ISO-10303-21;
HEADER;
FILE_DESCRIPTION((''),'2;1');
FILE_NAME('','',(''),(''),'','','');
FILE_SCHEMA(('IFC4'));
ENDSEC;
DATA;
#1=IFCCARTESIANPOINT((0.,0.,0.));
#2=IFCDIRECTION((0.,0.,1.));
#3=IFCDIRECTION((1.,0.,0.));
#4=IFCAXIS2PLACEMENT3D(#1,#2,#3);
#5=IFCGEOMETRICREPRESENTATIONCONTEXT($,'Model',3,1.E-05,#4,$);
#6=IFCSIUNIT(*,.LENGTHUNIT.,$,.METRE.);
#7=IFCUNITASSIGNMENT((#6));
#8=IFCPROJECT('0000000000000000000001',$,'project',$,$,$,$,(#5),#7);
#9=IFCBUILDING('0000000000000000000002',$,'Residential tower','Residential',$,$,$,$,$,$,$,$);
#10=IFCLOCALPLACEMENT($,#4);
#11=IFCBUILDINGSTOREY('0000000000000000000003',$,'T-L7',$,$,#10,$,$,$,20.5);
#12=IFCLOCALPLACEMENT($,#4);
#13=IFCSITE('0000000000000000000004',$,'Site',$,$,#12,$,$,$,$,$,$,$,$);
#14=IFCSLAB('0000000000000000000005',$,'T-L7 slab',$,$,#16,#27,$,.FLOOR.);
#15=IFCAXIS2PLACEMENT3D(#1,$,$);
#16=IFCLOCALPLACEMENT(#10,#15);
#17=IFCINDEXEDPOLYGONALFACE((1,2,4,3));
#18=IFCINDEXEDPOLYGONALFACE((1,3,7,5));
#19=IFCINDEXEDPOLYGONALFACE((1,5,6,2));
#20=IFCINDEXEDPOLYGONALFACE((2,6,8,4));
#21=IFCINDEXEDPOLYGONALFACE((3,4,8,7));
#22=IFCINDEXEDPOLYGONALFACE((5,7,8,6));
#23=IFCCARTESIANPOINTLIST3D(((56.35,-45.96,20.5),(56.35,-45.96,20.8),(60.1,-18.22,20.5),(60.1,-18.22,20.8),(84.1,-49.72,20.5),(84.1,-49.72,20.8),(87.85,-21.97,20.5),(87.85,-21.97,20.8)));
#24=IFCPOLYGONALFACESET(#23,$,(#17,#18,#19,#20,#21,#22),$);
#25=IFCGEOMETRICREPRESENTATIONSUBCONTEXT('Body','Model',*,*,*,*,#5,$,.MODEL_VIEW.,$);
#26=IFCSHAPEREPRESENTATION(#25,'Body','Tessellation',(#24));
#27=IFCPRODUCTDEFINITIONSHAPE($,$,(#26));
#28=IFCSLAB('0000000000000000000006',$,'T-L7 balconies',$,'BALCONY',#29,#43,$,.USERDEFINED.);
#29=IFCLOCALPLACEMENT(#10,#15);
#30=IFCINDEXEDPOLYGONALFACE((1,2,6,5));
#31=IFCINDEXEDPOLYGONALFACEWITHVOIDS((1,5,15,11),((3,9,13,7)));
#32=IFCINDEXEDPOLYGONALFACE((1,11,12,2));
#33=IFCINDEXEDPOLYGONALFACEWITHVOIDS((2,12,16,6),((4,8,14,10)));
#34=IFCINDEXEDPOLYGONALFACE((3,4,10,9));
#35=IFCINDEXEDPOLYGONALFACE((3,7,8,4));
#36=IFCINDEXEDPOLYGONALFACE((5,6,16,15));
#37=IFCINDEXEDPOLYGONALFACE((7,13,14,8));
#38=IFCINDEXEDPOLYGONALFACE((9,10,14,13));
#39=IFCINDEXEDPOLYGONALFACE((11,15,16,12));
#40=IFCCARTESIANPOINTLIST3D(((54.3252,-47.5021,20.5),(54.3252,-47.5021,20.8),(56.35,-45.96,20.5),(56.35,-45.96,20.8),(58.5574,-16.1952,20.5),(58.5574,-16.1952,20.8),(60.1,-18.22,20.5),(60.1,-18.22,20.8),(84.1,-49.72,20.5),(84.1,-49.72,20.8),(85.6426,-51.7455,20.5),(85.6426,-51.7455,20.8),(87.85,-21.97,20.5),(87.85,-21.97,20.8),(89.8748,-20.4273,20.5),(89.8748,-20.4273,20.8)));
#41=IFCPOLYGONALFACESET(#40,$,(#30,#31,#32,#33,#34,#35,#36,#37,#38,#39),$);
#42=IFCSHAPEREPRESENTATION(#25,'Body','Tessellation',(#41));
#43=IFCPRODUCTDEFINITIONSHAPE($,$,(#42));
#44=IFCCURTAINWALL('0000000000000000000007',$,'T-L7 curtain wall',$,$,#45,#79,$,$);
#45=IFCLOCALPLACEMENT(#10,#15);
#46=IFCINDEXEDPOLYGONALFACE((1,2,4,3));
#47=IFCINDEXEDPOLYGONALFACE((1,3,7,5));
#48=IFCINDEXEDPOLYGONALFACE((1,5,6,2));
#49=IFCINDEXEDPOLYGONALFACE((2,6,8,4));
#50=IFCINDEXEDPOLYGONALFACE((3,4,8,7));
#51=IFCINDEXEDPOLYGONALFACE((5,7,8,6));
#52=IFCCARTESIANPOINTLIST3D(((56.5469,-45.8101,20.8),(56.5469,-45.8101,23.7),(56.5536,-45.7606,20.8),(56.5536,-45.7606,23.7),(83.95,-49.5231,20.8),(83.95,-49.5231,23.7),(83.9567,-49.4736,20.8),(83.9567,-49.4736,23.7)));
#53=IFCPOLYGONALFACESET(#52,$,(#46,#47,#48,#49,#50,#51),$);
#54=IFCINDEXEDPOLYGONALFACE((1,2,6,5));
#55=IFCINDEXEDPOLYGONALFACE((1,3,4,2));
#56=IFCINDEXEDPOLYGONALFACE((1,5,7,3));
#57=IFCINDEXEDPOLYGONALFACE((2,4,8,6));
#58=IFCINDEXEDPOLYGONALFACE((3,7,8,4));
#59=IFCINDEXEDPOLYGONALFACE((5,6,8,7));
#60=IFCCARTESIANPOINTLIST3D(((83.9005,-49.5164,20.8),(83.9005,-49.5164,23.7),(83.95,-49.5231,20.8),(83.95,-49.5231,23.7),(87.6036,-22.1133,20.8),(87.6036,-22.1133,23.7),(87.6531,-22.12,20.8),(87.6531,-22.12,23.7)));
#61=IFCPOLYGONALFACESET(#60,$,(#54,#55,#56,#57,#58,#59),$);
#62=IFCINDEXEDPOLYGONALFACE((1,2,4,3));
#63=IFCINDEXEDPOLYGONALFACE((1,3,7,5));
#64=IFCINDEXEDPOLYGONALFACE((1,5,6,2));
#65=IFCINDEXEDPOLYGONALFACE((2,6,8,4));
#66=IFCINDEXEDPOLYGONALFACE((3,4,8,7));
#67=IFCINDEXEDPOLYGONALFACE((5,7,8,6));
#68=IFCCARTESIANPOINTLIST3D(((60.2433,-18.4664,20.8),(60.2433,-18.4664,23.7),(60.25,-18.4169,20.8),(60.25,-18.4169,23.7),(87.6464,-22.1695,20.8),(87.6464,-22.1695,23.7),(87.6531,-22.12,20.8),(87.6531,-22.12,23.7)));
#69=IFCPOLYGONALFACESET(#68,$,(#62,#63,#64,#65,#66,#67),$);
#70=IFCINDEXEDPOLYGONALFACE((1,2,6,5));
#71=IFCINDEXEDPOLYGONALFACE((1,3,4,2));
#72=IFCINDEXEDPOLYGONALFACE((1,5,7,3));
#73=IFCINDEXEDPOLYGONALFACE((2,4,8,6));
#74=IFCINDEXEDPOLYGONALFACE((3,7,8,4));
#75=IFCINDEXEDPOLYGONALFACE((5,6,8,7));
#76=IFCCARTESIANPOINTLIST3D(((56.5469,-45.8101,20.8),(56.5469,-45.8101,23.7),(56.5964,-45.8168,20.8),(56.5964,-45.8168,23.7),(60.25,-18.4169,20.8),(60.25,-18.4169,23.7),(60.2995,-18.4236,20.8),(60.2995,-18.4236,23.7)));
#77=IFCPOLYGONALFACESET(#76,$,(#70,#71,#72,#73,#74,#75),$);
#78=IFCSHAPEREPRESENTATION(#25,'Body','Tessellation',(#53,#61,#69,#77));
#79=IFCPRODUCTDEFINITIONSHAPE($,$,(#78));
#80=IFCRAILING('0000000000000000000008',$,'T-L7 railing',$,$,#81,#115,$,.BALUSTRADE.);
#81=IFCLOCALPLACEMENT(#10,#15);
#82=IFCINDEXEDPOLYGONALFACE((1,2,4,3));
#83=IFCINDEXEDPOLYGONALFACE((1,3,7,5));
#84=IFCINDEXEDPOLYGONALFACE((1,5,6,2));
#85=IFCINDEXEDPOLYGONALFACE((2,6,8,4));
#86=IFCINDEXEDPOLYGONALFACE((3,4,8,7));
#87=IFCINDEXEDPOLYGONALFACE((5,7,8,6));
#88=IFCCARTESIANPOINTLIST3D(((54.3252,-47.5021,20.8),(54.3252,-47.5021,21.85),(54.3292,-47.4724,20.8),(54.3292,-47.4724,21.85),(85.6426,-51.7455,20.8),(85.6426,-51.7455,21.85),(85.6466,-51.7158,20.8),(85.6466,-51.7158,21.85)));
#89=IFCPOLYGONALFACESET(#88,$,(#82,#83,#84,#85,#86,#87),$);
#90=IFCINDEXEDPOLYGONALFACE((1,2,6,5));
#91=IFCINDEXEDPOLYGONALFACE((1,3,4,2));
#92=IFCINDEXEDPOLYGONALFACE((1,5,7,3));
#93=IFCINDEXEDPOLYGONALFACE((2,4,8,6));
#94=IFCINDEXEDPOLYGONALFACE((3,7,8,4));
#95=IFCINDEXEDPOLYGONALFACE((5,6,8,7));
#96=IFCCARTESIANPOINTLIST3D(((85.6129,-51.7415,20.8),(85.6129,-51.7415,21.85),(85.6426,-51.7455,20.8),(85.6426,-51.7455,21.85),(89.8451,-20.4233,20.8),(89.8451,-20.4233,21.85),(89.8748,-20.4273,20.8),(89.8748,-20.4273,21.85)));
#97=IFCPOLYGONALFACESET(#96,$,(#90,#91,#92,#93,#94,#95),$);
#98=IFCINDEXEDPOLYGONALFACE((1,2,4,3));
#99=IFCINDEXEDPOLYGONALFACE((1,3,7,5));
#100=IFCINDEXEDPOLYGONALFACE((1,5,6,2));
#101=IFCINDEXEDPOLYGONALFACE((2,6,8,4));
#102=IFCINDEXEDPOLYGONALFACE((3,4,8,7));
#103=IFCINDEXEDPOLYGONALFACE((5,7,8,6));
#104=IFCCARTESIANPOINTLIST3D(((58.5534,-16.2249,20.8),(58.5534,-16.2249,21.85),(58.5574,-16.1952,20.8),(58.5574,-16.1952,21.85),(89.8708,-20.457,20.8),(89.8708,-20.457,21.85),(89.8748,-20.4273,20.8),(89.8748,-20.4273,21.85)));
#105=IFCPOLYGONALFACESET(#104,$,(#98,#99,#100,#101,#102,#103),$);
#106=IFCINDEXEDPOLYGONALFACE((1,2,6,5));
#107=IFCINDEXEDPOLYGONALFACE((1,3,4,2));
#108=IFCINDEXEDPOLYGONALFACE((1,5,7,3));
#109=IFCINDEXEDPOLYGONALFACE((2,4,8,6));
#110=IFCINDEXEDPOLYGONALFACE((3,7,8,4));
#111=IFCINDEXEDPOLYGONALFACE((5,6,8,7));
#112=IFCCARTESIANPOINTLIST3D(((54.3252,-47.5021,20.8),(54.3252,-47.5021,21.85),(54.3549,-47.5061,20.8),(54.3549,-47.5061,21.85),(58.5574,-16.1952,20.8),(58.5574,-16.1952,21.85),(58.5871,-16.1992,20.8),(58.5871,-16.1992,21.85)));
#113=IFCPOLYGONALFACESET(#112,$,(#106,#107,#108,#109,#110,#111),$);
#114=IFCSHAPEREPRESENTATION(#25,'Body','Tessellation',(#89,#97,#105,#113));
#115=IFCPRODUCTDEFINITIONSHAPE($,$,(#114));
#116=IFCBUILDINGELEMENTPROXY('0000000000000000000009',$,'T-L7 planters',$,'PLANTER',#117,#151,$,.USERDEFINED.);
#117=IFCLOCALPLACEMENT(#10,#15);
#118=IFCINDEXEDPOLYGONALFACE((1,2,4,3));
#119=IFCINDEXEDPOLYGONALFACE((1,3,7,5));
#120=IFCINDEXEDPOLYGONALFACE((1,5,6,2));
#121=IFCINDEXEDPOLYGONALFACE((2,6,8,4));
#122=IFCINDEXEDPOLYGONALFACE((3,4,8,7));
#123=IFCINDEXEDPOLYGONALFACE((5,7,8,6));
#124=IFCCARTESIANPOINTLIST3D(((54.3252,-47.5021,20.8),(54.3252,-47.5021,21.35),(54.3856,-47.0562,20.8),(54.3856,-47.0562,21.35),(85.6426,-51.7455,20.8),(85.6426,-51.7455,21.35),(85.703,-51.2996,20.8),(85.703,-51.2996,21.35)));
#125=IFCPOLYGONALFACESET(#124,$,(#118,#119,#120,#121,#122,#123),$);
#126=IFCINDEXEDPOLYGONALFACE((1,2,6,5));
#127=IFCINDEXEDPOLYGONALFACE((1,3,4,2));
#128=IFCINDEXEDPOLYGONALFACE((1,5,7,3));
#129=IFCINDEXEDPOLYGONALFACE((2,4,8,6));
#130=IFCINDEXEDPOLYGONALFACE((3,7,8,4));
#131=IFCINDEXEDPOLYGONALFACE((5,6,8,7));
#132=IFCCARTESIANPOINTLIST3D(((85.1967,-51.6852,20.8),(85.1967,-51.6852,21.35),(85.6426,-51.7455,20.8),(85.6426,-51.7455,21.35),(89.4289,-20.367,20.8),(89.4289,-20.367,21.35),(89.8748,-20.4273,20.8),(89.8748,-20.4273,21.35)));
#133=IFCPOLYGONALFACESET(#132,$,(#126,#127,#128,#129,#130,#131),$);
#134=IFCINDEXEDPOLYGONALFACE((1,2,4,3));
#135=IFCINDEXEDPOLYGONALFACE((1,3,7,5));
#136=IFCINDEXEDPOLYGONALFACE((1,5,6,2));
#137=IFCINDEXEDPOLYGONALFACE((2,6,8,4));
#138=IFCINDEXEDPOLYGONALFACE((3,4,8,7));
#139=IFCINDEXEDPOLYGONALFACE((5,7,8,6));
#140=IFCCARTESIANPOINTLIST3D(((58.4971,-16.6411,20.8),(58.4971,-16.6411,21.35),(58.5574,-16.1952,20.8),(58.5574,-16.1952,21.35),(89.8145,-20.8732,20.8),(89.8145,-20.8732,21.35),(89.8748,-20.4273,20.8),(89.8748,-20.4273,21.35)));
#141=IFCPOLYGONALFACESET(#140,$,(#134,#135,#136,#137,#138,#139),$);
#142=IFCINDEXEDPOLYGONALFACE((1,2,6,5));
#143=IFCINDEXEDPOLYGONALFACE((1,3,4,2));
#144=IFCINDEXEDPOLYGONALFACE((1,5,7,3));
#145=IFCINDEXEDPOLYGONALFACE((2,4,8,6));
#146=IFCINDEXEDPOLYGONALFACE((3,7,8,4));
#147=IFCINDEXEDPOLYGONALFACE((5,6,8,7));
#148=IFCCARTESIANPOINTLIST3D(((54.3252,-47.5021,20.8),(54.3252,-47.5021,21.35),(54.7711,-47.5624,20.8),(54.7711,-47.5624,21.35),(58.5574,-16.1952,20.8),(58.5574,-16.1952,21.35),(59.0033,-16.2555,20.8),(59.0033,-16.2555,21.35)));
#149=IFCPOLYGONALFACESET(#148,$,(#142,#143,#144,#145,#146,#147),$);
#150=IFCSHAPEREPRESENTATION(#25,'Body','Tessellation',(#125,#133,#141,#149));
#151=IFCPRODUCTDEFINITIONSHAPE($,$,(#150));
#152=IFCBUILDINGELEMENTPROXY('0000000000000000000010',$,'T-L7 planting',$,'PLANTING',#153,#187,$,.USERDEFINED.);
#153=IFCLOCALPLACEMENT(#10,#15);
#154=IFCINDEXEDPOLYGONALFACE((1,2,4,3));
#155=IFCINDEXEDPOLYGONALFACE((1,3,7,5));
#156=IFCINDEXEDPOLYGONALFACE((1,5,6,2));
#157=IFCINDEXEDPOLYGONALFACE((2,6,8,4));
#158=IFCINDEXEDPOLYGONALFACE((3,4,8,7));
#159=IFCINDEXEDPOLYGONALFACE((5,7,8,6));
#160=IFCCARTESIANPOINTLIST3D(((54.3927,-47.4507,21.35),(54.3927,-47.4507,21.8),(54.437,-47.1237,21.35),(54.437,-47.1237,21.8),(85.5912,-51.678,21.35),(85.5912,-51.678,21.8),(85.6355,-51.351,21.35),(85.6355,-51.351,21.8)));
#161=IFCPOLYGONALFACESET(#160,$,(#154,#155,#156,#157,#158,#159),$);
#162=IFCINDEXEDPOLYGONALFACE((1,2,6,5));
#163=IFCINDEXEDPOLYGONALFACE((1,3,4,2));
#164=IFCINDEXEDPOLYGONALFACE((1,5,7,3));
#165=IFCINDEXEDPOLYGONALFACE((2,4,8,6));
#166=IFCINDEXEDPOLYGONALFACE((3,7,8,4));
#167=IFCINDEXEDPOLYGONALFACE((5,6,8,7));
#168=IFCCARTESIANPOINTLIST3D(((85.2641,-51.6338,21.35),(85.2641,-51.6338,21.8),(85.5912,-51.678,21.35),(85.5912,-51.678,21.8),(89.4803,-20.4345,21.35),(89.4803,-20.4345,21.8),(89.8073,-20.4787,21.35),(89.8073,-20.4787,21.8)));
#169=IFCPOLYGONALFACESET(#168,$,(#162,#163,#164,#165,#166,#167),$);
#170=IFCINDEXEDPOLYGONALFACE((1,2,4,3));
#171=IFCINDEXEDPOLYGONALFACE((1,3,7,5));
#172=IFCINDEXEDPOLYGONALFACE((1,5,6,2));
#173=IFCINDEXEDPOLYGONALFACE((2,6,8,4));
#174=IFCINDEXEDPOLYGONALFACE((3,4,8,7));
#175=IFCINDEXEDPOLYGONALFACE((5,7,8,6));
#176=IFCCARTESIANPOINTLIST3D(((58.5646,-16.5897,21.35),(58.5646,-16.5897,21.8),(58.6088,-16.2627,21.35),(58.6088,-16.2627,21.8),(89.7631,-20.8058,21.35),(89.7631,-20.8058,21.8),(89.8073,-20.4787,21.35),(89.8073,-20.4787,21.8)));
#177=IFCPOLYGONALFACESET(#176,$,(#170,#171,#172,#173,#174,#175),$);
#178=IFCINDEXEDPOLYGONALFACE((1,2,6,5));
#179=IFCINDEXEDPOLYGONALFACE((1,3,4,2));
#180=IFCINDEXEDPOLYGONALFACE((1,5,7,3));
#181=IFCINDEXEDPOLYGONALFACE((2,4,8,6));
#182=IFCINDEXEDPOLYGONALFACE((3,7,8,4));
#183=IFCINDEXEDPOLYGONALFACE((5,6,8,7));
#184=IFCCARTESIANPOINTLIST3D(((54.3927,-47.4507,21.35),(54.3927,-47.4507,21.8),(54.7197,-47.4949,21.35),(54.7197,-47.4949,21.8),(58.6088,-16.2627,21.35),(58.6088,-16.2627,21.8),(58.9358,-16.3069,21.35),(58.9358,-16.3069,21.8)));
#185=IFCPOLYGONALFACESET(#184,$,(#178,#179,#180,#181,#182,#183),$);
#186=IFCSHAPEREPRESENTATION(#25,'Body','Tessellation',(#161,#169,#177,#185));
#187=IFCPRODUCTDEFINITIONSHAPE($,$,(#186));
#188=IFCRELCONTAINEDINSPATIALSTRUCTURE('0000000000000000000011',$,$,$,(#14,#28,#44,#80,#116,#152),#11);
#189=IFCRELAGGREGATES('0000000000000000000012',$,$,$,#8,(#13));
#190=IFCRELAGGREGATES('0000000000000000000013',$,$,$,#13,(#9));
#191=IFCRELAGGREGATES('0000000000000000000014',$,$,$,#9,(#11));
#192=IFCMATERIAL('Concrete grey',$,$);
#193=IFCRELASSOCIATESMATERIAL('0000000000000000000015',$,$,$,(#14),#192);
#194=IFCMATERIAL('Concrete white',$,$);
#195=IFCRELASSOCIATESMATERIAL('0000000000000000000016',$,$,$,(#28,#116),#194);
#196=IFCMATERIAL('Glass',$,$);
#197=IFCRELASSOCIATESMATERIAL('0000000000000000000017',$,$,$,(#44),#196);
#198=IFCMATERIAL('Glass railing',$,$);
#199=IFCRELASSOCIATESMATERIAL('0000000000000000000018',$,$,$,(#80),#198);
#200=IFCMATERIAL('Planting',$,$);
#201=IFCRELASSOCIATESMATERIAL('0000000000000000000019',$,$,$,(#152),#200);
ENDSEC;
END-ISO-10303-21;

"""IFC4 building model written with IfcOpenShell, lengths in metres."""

from ifc_helpers import new_model, si_unit, frame, origin_with_axes, place, context, subcontext, project, spatial, polyline, outline, extrude, material, element, save


model = new_model("IFC4")

# Units and contexts
model_context = context("Model", 3, precision=1e-05, world=origin_with_axes())
body_context = subcontext(model_context, "Body", "Model", "MODEL_VIEW")
ifc_project = project(units=[si_unit("LENGTHUNIT", "METRE")], contexts=[model_context])

# Site, building, storey
site_placement = place(None, origin_with_axes())
site = spatial("IfcSite", under=ifc_project, at=site_placement, Name="Site")
building = spatial("IfcBuilding", under=site, Name="Residential tower", Description="Residential")
storey_placement = place(None, origin_with_axes())
storey = spatial("IfcBuildingStorey", under=building, at=storey_placement, Name="T-L7", Elevation=20.5)

# Slabs
ifc_material_1 = material(Name="Concrete grey")
slab_1_placement = place(storey_placement, origin_with_axes())
element("IfcSlab", 1, at=slab_1_placement, inside=storey, material=ifc_material_1, Name="T-L7 slab", PredefinedType="FLOOR", context=body_context, shape_type="SweptSolid", body=[
    extrude(outline(polyline([(56.35, -45.96), (84.1, -49.72), (87.85, -21.97), (60.1, -18.22), (56.35, -45.96)])), frame((0.0, 0.0, 20.5), z_axis=(0.0, 0.0, 1.0), x_axis=(1.0, 0.0, 0.0)), (0.0, 0.0, 1.0), 0.3),
])
ifc_material_2 = material(Name="Concrete white")
slab_2_placement = place(storey_placement, origin_with_axes())
element("IfcSlab", 2, at=slab_2_placement, inside=storey, material=ifc_material_2, Name="T-L7 balconies", ObjectType="BALCONY", PredefinedType="USERDEFINED", context=body_context, shape_type="SweptSolid", body=[
    extrude(outline(polyline([(54.3252, -47.5021), (85.6426, -51.7455), (89.8748, -20.4273), (58.5574, -16.1952), (54.3252, -47.5021)]), holes=[polyline([(56.35, -45.96), (84.1, -49.72), (87.85, -21.97), (60.1, -18.22), (56.35, -45.96)])]), frame((0.0, 0.0, 20.5), z_axis=(0.0, 0.0, 1.0), x_axis=(1.0, 0.0, 0.0)), (0.0, 0.0, 1.0), 0.3),
])

# Curtain wall
ifc_material_3 = material(Name="Glass")
curtain_wall_placement = place(storey_placement, origin_with_axes())
element("IfcCurtainWall", 3, at=curtain_wall_placement, inside=storey, material=ifc_material_3, Name="T-L7 curtain wall", context=body_context, shape_type="SweptSolid", body=[
    extrude(outline(polyline([(56.5469, -45.8101), (83.95, -49.5231), (83.9567, -49.4736), (56.5536, -45.7606), (56.5469, -45.8101)])), frame((0.0, 0.0, 20.8), z_axis=(0.0, 0.0, 1.0), x_axis=(1.0, 0.0, 0.0)), (0.0, 0.0, 1.0), 2.9),
    extrude(outline(polyline([(83.95, -49.5231), (87.6531, -22.12), (87.6036, -22.1133), (83.9005, -49.5164), (83.95, -49.5231)])), frame((0.0, 0.0, 20.8), z_axis=(0.0, 0.0, 1.0), x_axis=(1.0, 0.0, 0.0)), (0.0, 0.0, 1.0), 2.9),
    extrude(outline(polyline([(87.6531, -22.12), (60.25, -18.4169), (60.2433, -18.4664), (87.6464, -22.1695), (87.6531, -22.12)])), frame((0.0, 0.0, 20.8), z_axis=(0.0, 0.0, 1.0), x_axis=(1.0, 0.0, 0.0)), (0.0, 0.0, 1.0), 2.9),
    extrude(outline(polyline([(60.25, -18.4169), (56.5469, -45.8101), (56.5964, -45.8168), (60.2995, -18.4236), (60.25, -18.4169)])), frame((0.0, 0.0, 20.8), z_axis=(0.0, 0.0, 1.0), x_axis=(1.0, 0.0, 0.0)), (0.0, 0.0, 1.0), 2.9),
])

# Railing
ifc_material_4 = material(Name="Glass railing")
railing_placement = place(storey_placement, origin_with_axes())
element("IfcRailing", 4, at=railing_placement, inside=storey, material=ifc_material_4, Name="T-L7 railing", PredefinedType="BALUSTRADE", context=body_context, shape_type="SweptSolid", body=[
    extrude(outline(polyline([(54.3252, -47.5021), (85.6426, -51.7455), (85.6466, -51.7158), (54.3292, -47.4724), (54.3252, -47.5021)])), frame((0.0, 0.0, 20.8), z_axis=(0.0, 0.0, 1.0), x_axis=(1.0, 0.0, 0.0)), (0.0, 0.0, 1.0), 1.05),
    extrude(outline(polyline([(85.6426, -51.7455), (89.8748, -20.4273), (89.8451, -20.4233), (85.6129, -51.7415), (85.6426, -51.7455)])), frame((0.0, 0.0, 20.8), z_axis=(0.0, 0.0, 1.0), x_axis=(1.0, 0.0, 0.0)), (0.0, 0.0, 1.0), 1.05),
    extrude(outline(polyline([(89.8748, -20.4273), (58.5574, -16.1952), (58.5534, -16.2249), (89.8708, -20.457), (89.8748, -20.4273)])), frame((0.0, 0.0, 20.8), z_axis=(0.0, 0.0, 1.0), x_axis=(1.0, 0.0, 0.0)), (0.0, 0.0, 1.0), 1.05),
    extrude(outline(polyline([(58.5574, -16.1952), (54.3252, -47.5021), (54.3549, -47.5061), (58.5871, -16.1992), (58.5574, -16.1952)])), frame((0.0, 0.0, 20.8), z_axis=(0.0, 0.0, 1.0), x_axis=(1.0, 0.0, 0.0)), (0.0, 0.0, 1.0), 1.05),
])

# Building element proxies
proxy_1_placement = place(storey_placement, origin_with_axes())
element("IfcBuildingElementProxy", 5, at=proxy_1_placement, inside=storey, material=ifc_material_2, Name="T-L7 planters", ObjectType="PLANTER", PredefinedType="USERDEFINED", context=body_context, shape_type="SweptSolid", body=[
    extrude(outline(polyline([(54.3252, -47.5021), (85.6426, -51.7455), (85.703, -51.2996), (54.3856, -47.0562), (54.3252, -47.5021)])), frame((0.0, 0.0, 20.8), z_axis=(0.0, 0.0, 1.0), x_axis=(1.0, 0.0, 0.0)), (0.0, 0.0, 1.0), 0.55),
    extrude(outline(polyline([(85.6426, -51.7455), (89.8748, -20.4273), (89.4289, -20.367), (85.1967, -51.6852), (85.6426, -51.7455)])), frame((0.0, 0.0, 20.8), z_axis=(0.0, 0.0, 1.0), x_axis=(1.0, 0.0, 0.0)), (0.0, 0.0, 1.0), 0.55),
    extrude(outline(polyline([(89.8748, -20.4273), (58.5574, -16.1952), (58.4971, -16.6411), (89.8145, -20.8732), (89.8748, -20.4273)])), frame((0.0, 0.0, 20.8), z_axis=(0.0, 0.0, 1.0), x_axis=(1.0, 0.0, 0.0)), (0.0, 0.0, 1.0), 0.55),
    extrude(outline(polyline([(58.5574, -16.1952), (54.3252, -47.5021), (54.7711, -47.5624), (59.0033, -16.2555), (58.5574, -16.1952)])), frame((0.0, 0.0, 20.8), z_axis=(0.0, 0.0, 1.0), x_axis=(1.0, 0.0, 0.0)), (0.0, 0.0, 1.0), 0.55),
])
ifc_material_5 = material(Name="Planting")
proxy_2_placement = place(storey_placement, origin_with_axes())
element("IfcBuildingElementProxy", 6, at=proxy_2_placement, inside=storey, material=ifc_material_5, Name="T-L7 planting", ObjectType="PLANTING", PredefinedType="USERDEFINED", context=body_context, shape_type="SweptSolid", body=[
    extrude(outline(polyline([(54.3927, -47.4507), (85.5912, -51.678), (85.6355, -51.351), (54.437, -47.1237), (54.3927, -47.4507)])), frame((0.0, 0.0, 21.35), z_axis=(0.0, 0.0, 1.0), x_axis=(1.0, 0.0, 0.0)), (0.0, 0.0, 1.0), 0.45),
    extrude(outline(polyline([(85.5912, -51.678), (89.8073, -20.4787), (89.4803, -20.4345), (85.2641, -51.6338), (85.5912, -51.678)])), frame((0.0, 0.0, 21.35), z_axis=(0.0, 0.0, 1.0), x_axis=(1.0, 0.0, 0.0)), (0.0, 0.0, 1.0), 0.45),
    extrude(outline(polyline([(89.8073, -20.4787), (58.6088, -16.2627), (58.5646, -16.5897), (89.7631, -20.8058), (89.8073, -20.4787)])), frame((0.0, 0.0, 21.35), z_axis=(0.0, 0.0, 1.0), x_axis=(1.0, 0.0, 0.0)), (0.0, 0.0, 1.0), 0.45),
    extrude(outline(polyline([(58.6088, -16.2627), (54.3927, -47.4507), (54.7197, -47.4949), (58.9358, -16.3069), (58.6088, -16.2627)])), frame((0.0, 0.0, 21.35), z_axis=(0.0, 0.0, 1.0), x_axis=(1.0, 0.0, 0.0)), (0.0, 0.0, 1.0), 0.45),
])

save(model, "model.ifc")
